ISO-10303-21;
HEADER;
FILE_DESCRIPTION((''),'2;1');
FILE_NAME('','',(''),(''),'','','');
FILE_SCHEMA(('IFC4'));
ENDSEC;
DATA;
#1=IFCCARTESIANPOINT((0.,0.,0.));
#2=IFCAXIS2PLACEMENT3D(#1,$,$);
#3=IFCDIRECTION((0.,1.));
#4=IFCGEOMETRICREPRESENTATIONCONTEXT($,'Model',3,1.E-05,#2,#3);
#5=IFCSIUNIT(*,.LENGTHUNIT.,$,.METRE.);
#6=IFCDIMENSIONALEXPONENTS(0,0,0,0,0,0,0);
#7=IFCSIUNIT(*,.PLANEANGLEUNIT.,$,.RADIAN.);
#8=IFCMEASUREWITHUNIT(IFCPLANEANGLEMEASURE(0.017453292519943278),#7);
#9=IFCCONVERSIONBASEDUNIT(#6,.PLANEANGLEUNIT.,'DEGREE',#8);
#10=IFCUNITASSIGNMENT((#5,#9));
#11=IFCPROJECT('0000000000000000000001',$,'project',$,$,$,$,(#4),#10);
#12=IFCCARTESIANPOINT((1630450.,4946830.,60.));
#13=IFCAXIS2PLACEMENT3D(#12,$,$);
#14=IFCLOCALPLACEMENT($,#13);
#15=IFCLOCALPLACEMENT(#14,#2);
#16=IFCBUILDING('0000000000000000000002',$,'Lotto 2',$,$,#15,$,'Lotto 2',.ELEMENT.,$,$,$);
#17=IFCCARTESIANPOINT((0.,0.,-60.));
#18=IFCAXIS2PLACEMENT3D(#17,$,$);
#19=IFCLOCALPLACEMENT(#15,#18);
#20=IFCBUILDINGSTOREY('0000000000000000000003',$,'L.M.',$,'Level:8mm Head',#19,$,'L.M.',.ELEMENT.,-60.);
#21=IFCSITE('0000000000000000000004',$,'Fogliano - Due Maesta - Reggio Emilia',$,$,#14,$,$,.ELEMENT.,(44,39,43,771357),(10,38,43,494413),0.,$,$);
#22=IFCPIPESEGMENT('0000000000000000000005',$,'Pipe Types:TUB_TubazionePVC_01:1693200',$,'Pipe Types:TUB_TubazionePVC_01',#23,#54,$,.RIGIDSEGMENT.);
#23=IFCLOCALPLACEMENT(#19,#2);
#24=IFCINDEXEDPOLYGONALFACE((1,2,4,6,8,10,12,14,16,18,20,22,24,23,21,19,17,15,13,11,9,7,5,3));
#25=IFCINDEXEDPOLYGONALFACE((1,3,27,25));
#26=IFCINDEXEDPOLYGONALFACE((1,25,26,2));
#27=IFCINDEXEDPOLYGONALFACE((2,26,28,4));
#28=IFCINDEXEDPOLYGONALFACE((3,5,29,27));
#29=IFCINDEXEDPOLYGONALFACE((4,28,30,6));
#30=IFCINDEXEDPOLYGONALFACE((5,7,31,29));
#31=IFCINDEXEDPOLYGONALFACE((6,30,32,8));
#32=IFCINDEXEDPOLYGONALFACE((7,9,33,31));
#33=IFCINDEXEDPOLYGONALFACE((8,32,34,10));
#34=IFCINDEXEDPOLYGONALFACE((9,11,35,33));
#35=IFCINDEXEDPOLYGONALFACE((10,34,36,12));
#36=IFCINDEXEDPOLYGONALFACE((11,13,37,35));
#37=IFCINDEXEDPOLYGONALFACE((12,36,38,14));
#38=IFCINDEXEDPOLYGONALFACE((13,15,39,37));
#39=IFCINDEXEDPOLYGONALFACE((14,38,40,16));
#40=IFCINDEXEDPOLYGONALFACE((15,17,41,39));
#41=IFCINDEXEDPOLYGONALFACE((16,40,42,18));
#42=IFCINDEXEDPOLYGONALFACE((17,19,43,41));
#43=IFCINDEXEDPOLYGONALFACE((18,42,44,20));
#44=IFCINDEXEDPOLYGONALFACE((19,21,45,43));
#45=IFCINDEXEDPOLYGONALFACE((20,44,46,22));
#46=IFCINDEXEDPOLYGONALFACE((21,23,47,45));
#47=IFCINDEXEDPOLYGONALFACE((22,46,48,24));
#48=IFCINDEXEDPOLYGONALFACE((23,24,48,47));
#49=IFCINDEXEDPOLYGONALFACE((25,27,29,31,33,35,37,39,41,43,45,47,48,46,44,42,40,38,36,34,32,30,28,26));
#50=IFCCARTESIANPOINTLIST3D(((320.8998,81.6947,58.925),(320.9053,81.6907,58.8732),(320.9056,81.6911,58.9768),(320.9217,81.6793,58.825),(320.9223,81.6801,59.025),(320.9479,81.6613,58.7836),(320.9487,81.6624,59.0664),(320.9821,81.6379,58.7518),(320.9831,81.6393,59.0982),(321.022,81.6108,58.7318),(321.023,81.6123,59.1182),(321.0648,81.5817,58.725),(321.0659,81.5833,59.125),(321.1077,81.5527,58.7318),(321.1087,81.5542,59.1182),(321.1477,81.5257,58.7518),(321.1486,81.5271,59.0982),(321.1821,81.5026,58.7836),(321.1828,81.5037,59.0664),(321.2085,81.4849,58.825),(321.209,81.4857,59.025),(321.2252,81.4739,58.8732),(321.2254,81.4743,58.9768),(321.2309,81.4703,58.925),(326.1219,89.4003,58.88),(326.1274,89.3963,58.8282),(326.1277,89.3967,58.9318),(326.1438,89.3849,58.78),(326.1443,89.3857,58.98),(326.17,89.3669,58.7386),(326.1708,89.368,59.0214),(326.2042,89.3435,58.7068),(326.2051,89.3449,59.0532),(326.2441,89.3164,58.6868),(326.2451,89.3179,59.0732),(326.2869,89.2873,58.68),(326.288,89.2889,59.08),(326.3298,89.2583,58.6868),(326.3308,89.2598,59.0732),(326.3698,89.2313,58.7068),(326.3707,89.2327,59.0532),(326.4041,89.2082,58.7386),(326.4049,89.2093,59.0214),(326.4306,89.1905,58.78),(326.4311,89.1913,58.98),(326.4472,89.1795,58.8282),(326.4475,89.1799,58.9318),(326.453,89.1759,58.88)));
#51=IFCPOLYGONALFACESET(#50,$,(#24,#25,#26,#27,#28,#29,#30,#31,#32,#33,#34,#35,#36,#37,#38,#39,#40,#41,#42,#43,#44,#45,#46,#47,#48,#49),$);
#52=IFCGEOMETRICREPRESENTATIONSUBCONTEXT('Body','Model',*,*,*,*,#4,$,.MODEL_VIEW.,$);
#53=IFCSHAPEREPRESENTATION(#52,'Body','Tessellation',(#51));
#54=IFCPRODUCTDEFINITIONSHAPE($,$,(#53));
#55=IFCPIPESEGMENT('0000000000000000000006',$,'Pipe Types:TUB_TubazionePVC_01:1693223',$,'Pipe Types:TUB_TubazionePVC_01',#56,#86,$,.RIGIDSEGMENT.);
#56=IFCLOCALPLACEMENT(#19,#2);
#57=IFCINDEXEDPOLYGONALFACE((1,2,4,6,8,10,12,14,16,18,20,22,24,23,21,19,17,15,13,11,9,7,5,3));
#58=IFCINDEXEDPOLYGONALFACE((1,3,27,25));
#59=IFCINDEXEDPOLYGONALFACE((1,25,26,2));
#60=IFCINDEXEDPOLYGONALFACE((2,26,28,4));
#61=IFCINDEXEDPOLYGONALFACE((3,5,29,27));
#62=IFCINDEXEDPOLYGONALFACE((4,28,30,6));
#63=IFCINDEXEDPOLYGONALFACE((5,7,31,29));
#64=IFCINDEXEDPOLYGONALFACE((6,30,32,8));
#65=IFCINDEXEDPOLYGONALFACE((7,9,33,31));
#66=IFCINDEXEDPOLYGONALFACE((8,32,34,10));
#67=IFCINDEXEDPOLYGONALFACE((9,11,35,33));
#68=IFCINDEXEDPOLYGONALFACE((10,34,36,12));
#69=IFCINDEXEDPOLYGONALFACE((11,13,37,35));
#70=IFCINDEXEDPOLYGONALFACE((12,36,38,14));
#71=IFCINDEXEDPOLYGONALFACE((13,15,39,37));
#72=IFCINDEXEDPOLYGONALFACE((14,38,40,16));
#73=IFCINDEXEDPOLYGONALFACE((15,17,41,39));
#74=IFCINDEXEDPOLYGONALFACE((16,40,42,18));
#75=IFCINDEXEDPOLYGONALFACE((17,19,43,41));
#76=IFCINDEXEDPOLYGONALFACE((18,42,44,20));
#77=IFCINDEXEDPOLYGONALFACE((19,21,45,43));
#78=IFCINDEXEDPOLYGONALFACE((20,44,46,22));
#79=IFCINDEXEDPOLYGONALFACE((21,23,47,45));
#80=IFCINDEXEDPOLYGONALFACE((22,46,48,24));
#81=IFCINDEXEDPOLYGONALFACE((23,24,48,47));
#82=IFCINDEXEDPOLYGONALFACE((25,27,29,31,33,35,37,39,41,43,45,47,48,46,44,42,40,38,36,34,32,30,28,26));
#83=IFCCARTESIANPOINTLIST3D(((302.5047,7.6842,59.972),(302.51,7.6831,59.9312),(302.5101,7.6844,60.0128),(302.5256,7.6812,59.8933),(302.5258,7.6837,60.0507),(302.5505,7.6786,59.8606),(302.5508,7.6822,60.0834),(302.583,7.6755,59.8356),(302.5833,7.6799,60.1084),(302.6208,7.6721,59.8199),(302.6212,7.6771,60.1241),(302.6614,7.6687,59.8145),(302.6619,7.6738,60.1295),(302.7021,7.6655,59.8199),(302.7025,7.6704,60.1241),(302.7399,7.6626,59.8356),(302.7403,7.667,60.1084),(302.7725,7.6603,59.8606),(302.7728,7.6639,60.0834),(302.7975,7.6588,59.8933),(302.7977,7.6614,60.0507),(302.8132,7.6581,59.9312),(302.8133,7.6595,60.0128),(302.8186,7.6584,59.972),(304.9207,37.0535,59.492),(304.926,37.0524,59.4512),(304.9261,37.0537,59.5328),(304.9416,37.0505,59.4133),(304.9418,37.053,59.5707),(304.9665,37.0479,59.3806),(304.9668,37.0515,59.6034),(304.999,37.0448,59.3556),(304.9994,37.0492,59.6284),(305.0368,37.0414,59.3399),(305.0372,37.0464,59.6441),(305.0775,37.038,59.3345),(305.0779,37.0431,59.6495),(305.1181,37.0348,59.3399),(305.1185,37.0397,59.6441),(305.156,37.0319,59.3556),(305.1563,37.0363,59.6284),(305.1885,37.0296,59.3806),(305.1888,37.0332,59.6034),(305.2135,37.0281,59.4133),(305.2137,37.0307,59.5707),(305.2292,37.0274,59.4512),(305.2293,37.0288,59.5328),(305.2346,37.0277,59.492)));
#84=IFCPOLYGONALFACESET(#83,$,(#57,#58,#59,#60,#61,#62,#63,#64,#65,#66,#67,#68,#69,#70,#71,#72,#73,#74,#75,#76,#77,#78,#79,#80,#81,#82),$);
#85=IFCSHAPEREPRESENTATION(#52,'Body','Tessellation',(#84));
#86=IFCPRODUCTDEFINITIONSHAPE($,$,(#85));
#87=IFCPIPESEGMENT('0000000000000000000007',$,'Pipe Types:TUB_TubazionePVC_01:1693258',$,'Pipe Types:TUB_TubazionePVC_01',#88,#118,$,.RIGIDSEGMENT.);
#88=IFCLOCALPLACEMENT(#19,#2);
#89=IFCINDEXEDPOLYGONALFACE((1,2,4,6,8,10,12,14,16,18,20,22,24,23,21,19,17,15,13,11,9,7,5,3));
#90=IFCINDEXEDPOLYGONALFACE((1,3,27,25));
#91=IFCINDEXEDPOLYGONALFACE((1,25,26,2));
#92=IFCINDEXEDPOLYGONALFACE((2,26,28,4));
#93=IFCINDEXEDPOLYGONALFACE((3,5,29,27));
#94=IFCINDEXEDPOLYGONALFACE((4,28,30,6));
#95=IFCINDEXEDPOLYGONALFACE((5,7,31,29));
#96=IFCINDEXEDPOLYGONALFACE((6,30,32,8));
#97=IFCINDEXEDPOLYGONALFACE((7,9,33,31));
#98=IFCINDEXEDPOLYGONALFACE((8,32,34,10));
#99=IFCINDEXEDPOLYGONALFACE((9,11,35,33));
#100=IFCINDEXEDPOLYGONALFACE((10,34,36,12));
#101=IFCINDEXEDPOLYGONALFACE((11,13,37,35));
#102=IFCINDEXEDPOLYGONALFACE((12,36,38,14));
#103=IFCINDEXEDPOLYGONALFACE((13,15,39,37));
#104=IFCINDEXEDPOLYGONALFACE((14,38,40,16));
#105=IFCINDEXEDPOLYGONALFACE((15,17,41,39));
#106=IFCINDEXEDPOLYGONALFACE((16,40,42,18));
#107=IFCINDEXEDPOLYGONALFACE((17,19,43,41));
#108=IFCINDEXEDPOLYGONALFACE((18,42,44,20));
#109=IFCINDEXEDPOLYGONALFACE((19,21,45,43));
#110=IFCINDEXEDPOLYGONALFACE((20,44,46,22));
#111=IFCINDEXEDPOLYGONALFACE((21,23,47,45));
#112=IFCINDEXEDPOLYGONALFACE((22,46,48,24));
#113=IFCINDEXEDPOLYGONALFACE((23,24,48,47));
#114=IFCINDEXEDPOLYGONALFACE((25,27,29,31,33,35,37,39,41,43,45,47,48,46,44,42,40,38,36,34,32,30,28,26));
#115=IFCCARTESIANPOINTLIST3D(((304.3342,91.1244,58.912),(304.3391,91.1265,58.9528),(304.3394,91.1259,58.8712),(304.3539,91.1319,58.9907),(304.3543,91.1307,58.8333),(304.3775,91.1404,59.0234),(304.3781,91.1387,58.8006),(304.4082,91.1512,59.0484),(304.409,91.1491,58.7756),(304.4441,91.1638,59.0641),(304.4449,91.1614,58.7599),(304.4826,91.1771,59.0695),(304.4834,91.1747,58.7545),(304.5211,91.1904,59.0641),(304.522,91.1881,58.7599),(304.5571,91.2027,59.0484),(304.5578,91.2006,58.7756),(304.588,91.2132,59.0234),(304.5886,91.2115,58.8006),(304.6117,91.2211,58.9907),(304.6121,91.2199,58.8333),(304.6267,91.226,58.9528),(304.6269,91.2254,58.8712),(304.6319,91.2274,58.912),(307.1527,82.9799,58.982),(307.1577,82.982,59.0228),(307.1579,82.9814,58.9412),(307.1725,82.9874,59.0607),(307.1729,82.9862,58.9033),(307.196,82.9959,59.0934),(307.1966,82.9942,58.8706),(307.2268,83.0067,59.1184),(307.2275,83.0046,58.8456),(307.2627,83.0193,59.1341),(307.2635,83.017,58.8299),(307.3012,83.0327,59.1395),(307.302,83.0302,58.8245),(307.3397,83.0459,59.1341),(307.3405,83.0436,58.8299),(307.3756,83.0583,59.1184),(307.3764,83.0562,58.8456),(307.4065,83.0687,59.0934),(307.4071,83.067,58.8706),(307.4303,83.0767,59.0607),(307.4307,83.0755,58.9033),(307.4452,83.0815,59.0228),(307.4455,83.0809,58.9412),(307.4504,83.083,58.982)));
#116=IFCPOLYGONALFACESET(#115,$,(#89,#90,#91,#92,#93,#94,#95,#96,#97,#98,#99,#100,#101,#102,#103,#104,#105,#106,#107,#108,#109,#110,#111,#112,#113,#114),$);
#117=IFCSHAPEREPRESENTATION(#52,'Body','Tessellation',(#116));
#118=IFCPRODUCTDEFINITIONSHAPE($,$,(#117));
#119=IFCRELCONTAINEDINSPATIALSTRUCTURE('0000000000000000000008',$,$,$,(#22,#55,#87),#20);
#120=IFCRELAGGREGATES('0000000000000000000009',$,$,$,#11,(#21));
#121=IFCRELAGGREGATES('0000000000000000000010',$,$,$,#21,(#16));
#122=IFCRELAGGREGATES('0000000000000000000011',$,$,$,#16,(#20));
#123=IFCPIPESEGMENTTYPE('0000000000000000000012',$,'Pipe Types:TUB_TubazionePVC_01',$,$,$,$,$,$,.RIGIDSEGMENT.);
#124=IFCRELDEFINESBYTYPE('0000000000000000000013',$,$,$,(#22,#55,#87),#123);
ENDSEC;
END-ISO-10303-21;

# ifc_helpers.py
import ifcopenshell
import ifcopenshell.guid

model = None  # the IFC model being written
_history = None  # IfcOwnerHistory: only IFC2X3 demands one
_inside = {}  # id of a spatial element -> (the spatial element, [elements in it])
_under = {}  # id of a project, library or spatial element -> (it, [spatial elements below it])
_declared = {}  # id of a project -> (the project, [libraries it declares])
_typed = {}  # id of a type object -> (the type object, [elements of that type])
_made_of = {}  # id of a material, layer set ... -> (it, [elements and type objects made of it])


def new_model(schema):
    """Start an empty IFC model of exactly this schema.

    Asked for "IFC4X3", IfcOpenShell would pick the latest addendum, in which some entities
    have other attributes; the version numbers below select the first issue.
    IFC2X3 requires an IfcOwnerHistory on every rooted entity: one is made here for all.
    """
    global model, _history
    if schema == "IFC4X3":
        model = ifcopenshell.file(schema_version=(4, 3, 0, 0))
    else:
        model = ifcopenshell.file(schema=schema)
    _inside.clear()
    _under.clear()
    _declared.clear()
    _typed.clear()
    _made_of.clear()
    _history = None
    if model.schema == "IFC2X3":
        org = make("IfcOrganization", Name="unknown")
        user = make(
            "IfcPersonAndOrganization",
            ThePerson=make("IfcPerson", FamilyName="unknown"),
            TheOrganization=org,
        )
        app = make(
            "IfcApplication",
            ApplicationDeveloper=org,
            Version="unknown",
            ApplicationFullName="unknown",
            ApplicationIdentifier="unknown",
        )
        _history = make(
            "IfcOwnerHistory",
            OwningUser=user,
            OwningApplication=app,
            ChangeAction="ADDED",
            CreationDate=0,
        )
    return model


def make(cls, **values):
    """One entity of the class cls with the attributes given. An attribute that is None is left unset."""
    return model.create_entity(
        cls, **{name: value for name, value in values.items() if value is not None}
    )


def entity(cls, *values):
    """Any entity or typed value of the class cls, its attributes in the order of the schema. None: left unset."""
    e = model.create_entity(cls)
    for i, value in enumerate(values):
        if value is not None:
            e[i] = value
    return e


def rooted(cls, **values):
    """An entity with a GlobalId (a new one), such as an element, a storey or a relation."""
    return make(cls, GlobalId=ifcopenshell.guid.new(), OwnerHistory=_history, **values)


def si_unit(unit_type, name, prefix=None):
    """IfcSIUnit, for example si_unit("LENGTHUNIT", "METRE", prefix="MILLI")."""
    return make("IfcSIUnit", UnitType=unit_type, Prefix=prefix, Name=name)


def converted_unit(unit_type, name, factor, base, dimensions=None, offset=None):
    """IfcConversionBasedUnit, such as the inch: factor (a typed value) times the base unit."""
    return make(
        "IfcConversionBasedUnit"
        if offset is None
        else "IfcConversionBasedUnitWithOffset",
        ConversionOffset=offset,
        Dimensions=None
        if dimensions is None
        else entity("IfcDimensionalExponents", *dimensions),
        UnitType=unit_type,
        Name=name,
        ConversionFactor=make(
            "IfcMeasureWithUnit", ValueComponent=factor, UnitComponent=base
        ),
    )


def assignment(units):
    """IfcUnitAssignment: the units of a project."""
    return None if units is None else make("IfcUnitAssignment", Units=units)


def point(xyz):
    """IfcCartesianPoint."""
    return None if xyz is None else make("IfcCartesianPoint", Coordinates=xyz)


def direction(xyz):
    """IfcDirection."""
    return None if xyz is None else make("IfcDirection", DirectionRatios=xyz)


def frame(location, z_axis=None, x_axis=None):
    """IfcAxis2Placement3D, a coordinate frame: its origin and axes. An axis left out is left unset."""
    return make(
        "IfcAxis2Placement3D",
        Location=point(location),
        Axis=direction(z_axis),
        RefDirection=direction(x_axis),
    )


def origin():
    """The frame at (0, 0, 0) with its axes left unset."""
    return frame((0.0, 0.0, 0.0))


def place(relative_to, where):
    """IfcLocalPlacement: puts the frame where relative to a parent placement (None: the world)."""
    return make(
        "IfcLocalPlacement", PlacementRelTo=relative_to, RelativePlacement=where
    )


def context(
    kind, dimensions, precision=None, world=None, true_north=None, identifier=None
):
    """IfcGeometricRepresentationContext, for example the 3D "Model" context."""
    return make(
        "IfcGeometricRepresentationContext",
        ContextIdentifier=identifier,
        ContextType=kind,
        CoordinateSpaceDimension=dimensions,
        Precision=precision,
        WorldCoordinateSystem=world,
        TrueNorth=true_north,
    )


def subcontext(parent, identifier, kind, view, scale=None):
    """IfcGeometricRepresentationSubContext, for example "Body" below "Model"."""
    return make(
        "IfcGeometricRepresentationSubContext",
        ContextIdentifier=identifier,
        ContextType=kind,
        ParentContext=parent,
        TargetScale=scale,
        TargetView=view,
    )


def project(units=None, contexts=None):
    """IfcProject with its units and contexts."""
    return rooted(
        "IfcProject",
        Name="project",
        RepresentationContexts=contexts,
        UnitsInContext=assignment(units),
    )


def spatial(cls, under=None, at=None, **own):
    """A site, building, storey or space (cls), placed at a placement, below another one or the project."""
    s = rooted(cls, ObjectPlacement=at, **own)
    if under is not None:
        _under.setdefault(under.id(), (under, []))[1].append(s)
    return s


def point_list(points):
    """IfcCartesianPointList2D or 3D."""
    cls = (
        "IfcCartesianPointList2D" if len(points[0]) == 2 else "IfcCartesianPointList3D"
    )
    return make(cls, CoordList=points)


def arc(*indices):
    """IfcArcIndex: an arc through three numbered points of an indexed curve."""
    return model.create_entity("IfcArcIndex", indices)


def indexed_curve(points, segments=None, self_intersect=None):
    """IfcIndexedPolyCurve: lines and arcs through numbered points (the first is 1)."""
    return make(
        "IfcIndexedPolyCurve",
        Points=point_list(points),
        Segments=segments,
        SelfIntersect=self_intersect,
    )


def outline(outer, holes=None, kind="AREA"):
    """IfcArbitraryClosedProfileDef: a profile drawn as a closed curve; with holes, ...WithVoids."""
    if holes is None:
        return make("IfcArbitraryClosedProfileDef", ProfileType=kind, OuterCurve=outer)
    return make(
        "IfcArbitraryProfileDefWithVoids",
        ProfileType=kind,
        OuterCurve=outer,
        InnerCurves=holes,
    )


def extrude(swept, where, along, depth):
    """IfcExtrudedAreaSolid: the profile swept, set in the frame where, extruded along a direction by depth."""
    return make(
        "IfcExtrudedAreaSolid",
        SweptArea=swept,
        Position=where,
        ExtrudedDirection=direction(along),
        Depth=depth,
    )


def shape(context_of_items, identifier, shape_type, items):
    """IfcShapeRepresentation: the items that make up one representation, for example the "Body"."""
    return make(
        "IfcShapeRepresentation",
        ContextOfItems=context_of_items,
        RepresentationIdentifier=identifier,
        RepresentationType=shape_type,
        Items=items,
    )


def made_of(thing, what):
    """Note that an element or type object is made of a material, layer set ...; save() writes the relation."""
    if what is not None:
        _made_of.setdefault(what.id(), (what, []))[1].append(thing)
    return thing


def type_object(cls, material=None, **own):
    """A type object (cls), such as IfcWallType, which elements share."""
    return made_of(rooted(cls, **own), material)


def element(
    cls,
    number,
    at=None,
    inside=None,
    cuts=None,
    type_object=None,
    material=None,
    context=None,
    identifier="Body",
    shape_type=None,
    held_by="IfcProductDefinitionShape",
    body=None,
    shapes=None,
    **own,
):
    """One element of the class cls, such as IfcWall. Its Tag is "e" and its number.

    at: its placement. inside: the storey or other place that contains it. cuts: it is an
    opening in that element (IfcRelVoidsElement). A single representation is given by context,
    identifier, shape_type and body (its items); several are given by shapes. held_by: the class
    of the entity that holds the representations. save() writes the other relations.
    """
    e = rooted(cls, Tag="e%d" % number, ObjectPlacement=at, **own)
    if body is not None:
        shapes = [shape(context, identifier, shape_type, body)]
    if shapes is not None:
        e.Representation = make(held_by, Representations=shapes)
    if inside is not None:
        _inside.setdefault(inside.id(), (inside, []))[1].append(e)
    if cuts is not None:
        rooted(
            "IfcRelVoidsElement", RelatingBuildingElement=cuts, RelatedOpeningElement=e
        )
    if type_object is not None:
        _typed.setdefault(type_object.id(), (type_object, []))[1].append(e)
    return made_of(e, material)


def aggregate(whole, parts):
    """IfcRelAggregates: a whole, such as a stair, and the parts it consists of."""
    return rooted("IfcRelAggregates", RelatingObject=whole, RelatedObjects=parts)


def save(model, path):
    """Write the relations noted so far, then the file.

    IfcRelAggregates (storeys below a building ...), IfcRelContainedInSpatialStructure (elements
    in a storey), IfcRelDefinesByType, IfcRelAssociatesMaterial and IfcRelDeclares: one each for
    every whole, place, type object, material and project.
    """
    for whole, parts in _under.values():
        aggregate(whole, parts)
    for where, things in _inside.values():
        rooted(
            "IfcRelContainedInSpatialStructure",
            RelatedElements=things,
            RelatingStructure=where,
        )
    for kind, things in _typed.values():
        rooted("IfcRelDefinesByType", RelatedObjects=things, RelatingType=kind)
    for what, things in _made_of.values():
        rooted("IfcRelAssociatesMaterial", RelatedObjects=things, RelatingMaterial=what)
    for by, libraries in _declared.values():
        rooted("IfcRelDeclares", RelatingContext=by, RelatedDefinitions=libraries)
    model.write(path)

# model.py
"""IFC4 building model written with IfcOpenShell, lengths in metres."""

from ifc_helpers import new_model, entity, si_unit, converted_unit, direction, frame, origin, place, context, subcontext, project, spatial, arc, indexed_curve, outline, extrude, type_object, element, save


model = new_model("IFC4")

# Units and contexts
model_context = context("Model", 3, precision=1e-05, world=origin(), true_north=direction((0.0, 1.0)))
body_context = subcontext(model_context, "Body", "Model", "MODEL_VIEW")
ifc_project = project(units=[si_unit("LENGTHUNIT", "METRE"), converted_unit("PLANEANGLEUNIT", "DEGREE", entity("IfcPlaneAngleMeasure", 0.017453292519943278), si_unit("PLANEANGLEUNIT", "RADIAN"), dimensions=[0, 0, 0, 0, 0, 0, 0])], contexts=[model_context])

# Site, building, storey
site_placement = place(None, frame((1630450.0, 4946830.0, 60.0)))
site = spatial("IfcSite", under=ifc_project, at=site_placement, Name="Fogliano - Due Maesta - Reggio Emilia", CompositionType="ELEMENT", RefLatitude=(44, 39, 43, 771357), RefLongitude=(10, 38, 43, 494413), RefElevation=0.0)
building_placement = place(site_placement, origin())
building = spatial("IfcBuilding", under=site, at=building_placement, Name="Lotto 2", LongName="Lotto 2", CompositionType="ELEMENT")
storey_placement = place(building_placement, frame((0.0, 0.0, -60.0)))
storey = spatial("IfcBuildingStorey", under=building, at=storey_placement, Name="L.M.", ObjectType="Level:8mm Head", LongName="L.M.", CompositionType="ELEMENT", Elevation=-60.0)

# Pipe segments
pipe_segment_type = type_object("IfcPipeSegmentType", Name="Pipe Types:TUB_TubazionePVC_01", PredefinedType="RIGIDSEGMENT")
pipe_segment_1_placement = place(storey_placement, origin())
element("IfcPipeSegment", 1, at=pipe_segment_1_placement, inside=storey, type_object=pipe_segment_type, Name="Pipe Types:TUB_TubazionePVC_01:1693200", ObjectType="Pipe Types:TUB_TubazionePVC_01", PredefinedType="RIGIDSEGMENT", context=body_context, shape_type="SweptSolid", body=[
    extrude(outline(indexed_curve([(0.2, 0.0), (0.1414, 0.1414), (0.0, 0.2), (-0.1414, 0.1414), (-0.2, 0.0), (-0.1414, -0.1414), (0.0, -0.2), (0.1414, -0.1414)], segments=[arc(1, 2, 3), arc(3, 4, 5), arc(5, 6, 7), arc(7, 8, 1)], self_intersect=False)), frame((326.2875, 89.2881, 58.88), z_axis=(-0.561001, -0.827801, 0.004834), x_axis=(0.827811, -0.561007, 0.0)), (0.0, 0.0, 1.0), 9.3085),
])
pipe_segment_2_placement = place(storey_placement, origin())
element("IfcPipeSegment", 2, at=pipe_segment_2_placement, inside=storey, type_object=pipe_segment_type, Name="Pipe Types:TUB_TubazionePVC_01:1693223", ObjectType="Pipe Types:TUB_TubazionePVC_01", PredefinedType="RIGIDSEGMENT", context=body_context, shape_type="SweptSolid", body=[
    extrude(outline(indexed_curve([(0.1575, 0.0), (0.1114, 0.1114), (0.0, 0.1575), (-0.1114, 0.1114), (-0.1575, 0.0), (-0.1114, -0.1114), (0.0, -0.1575), (0.1114, -0.1114)], segments=[arc(1, 2, 3), arc(3, 4, 5), arc(5, 6, 7), arc(7, 8, 1)], self_intersect=False)), frame((305.0777, 37.0406, 59.492), z_axis=(-0.081976, -0.996501, 0.016286), x_axis=(0.996633, -0.081987, 0.0)), (0.0, 0.0, 1.0), 29.4724),
])
pipe_segment_3_placement = place(storey_placement, origin())
element("IfcPipeSegment", 3, at=pipe_segment_3_placement, inside=storey, type_object=pipe_segment_type, Name="Pipe Types:TUB_TubazionePVC_01:1693258", ObjectType="Pipe Types:TUB_TubazionePVC_01", PredefinedType="RIGIDSEGMENT", context=body_context, shape_type="SweptSolid", body=[
    extrude(outline(indexed_curve([(0.1575, 0.0), (0.1114, 0.1114), (0.0, 0.1575), (-0.1114, 0.1114), (-0.1575, 0.0), (-0.1114, -0.1114), (0.0, -0.1575), (0.1114, -0.1114)], segments=[arc(1, 2, 3), arc(3, 4, 5), arc(5, 6, 7), arc(7, 8, 1)], self_intersect=False)), frame((304.483, 91.1759, 58.912), z_axis=(0.327029, -0.944979, 0.008122), x_axis=(0.945011, 0.32704, 0.0)), (0.0, 0.0, 1.0), 8.6187),
])

save(model, "model.ifc")
